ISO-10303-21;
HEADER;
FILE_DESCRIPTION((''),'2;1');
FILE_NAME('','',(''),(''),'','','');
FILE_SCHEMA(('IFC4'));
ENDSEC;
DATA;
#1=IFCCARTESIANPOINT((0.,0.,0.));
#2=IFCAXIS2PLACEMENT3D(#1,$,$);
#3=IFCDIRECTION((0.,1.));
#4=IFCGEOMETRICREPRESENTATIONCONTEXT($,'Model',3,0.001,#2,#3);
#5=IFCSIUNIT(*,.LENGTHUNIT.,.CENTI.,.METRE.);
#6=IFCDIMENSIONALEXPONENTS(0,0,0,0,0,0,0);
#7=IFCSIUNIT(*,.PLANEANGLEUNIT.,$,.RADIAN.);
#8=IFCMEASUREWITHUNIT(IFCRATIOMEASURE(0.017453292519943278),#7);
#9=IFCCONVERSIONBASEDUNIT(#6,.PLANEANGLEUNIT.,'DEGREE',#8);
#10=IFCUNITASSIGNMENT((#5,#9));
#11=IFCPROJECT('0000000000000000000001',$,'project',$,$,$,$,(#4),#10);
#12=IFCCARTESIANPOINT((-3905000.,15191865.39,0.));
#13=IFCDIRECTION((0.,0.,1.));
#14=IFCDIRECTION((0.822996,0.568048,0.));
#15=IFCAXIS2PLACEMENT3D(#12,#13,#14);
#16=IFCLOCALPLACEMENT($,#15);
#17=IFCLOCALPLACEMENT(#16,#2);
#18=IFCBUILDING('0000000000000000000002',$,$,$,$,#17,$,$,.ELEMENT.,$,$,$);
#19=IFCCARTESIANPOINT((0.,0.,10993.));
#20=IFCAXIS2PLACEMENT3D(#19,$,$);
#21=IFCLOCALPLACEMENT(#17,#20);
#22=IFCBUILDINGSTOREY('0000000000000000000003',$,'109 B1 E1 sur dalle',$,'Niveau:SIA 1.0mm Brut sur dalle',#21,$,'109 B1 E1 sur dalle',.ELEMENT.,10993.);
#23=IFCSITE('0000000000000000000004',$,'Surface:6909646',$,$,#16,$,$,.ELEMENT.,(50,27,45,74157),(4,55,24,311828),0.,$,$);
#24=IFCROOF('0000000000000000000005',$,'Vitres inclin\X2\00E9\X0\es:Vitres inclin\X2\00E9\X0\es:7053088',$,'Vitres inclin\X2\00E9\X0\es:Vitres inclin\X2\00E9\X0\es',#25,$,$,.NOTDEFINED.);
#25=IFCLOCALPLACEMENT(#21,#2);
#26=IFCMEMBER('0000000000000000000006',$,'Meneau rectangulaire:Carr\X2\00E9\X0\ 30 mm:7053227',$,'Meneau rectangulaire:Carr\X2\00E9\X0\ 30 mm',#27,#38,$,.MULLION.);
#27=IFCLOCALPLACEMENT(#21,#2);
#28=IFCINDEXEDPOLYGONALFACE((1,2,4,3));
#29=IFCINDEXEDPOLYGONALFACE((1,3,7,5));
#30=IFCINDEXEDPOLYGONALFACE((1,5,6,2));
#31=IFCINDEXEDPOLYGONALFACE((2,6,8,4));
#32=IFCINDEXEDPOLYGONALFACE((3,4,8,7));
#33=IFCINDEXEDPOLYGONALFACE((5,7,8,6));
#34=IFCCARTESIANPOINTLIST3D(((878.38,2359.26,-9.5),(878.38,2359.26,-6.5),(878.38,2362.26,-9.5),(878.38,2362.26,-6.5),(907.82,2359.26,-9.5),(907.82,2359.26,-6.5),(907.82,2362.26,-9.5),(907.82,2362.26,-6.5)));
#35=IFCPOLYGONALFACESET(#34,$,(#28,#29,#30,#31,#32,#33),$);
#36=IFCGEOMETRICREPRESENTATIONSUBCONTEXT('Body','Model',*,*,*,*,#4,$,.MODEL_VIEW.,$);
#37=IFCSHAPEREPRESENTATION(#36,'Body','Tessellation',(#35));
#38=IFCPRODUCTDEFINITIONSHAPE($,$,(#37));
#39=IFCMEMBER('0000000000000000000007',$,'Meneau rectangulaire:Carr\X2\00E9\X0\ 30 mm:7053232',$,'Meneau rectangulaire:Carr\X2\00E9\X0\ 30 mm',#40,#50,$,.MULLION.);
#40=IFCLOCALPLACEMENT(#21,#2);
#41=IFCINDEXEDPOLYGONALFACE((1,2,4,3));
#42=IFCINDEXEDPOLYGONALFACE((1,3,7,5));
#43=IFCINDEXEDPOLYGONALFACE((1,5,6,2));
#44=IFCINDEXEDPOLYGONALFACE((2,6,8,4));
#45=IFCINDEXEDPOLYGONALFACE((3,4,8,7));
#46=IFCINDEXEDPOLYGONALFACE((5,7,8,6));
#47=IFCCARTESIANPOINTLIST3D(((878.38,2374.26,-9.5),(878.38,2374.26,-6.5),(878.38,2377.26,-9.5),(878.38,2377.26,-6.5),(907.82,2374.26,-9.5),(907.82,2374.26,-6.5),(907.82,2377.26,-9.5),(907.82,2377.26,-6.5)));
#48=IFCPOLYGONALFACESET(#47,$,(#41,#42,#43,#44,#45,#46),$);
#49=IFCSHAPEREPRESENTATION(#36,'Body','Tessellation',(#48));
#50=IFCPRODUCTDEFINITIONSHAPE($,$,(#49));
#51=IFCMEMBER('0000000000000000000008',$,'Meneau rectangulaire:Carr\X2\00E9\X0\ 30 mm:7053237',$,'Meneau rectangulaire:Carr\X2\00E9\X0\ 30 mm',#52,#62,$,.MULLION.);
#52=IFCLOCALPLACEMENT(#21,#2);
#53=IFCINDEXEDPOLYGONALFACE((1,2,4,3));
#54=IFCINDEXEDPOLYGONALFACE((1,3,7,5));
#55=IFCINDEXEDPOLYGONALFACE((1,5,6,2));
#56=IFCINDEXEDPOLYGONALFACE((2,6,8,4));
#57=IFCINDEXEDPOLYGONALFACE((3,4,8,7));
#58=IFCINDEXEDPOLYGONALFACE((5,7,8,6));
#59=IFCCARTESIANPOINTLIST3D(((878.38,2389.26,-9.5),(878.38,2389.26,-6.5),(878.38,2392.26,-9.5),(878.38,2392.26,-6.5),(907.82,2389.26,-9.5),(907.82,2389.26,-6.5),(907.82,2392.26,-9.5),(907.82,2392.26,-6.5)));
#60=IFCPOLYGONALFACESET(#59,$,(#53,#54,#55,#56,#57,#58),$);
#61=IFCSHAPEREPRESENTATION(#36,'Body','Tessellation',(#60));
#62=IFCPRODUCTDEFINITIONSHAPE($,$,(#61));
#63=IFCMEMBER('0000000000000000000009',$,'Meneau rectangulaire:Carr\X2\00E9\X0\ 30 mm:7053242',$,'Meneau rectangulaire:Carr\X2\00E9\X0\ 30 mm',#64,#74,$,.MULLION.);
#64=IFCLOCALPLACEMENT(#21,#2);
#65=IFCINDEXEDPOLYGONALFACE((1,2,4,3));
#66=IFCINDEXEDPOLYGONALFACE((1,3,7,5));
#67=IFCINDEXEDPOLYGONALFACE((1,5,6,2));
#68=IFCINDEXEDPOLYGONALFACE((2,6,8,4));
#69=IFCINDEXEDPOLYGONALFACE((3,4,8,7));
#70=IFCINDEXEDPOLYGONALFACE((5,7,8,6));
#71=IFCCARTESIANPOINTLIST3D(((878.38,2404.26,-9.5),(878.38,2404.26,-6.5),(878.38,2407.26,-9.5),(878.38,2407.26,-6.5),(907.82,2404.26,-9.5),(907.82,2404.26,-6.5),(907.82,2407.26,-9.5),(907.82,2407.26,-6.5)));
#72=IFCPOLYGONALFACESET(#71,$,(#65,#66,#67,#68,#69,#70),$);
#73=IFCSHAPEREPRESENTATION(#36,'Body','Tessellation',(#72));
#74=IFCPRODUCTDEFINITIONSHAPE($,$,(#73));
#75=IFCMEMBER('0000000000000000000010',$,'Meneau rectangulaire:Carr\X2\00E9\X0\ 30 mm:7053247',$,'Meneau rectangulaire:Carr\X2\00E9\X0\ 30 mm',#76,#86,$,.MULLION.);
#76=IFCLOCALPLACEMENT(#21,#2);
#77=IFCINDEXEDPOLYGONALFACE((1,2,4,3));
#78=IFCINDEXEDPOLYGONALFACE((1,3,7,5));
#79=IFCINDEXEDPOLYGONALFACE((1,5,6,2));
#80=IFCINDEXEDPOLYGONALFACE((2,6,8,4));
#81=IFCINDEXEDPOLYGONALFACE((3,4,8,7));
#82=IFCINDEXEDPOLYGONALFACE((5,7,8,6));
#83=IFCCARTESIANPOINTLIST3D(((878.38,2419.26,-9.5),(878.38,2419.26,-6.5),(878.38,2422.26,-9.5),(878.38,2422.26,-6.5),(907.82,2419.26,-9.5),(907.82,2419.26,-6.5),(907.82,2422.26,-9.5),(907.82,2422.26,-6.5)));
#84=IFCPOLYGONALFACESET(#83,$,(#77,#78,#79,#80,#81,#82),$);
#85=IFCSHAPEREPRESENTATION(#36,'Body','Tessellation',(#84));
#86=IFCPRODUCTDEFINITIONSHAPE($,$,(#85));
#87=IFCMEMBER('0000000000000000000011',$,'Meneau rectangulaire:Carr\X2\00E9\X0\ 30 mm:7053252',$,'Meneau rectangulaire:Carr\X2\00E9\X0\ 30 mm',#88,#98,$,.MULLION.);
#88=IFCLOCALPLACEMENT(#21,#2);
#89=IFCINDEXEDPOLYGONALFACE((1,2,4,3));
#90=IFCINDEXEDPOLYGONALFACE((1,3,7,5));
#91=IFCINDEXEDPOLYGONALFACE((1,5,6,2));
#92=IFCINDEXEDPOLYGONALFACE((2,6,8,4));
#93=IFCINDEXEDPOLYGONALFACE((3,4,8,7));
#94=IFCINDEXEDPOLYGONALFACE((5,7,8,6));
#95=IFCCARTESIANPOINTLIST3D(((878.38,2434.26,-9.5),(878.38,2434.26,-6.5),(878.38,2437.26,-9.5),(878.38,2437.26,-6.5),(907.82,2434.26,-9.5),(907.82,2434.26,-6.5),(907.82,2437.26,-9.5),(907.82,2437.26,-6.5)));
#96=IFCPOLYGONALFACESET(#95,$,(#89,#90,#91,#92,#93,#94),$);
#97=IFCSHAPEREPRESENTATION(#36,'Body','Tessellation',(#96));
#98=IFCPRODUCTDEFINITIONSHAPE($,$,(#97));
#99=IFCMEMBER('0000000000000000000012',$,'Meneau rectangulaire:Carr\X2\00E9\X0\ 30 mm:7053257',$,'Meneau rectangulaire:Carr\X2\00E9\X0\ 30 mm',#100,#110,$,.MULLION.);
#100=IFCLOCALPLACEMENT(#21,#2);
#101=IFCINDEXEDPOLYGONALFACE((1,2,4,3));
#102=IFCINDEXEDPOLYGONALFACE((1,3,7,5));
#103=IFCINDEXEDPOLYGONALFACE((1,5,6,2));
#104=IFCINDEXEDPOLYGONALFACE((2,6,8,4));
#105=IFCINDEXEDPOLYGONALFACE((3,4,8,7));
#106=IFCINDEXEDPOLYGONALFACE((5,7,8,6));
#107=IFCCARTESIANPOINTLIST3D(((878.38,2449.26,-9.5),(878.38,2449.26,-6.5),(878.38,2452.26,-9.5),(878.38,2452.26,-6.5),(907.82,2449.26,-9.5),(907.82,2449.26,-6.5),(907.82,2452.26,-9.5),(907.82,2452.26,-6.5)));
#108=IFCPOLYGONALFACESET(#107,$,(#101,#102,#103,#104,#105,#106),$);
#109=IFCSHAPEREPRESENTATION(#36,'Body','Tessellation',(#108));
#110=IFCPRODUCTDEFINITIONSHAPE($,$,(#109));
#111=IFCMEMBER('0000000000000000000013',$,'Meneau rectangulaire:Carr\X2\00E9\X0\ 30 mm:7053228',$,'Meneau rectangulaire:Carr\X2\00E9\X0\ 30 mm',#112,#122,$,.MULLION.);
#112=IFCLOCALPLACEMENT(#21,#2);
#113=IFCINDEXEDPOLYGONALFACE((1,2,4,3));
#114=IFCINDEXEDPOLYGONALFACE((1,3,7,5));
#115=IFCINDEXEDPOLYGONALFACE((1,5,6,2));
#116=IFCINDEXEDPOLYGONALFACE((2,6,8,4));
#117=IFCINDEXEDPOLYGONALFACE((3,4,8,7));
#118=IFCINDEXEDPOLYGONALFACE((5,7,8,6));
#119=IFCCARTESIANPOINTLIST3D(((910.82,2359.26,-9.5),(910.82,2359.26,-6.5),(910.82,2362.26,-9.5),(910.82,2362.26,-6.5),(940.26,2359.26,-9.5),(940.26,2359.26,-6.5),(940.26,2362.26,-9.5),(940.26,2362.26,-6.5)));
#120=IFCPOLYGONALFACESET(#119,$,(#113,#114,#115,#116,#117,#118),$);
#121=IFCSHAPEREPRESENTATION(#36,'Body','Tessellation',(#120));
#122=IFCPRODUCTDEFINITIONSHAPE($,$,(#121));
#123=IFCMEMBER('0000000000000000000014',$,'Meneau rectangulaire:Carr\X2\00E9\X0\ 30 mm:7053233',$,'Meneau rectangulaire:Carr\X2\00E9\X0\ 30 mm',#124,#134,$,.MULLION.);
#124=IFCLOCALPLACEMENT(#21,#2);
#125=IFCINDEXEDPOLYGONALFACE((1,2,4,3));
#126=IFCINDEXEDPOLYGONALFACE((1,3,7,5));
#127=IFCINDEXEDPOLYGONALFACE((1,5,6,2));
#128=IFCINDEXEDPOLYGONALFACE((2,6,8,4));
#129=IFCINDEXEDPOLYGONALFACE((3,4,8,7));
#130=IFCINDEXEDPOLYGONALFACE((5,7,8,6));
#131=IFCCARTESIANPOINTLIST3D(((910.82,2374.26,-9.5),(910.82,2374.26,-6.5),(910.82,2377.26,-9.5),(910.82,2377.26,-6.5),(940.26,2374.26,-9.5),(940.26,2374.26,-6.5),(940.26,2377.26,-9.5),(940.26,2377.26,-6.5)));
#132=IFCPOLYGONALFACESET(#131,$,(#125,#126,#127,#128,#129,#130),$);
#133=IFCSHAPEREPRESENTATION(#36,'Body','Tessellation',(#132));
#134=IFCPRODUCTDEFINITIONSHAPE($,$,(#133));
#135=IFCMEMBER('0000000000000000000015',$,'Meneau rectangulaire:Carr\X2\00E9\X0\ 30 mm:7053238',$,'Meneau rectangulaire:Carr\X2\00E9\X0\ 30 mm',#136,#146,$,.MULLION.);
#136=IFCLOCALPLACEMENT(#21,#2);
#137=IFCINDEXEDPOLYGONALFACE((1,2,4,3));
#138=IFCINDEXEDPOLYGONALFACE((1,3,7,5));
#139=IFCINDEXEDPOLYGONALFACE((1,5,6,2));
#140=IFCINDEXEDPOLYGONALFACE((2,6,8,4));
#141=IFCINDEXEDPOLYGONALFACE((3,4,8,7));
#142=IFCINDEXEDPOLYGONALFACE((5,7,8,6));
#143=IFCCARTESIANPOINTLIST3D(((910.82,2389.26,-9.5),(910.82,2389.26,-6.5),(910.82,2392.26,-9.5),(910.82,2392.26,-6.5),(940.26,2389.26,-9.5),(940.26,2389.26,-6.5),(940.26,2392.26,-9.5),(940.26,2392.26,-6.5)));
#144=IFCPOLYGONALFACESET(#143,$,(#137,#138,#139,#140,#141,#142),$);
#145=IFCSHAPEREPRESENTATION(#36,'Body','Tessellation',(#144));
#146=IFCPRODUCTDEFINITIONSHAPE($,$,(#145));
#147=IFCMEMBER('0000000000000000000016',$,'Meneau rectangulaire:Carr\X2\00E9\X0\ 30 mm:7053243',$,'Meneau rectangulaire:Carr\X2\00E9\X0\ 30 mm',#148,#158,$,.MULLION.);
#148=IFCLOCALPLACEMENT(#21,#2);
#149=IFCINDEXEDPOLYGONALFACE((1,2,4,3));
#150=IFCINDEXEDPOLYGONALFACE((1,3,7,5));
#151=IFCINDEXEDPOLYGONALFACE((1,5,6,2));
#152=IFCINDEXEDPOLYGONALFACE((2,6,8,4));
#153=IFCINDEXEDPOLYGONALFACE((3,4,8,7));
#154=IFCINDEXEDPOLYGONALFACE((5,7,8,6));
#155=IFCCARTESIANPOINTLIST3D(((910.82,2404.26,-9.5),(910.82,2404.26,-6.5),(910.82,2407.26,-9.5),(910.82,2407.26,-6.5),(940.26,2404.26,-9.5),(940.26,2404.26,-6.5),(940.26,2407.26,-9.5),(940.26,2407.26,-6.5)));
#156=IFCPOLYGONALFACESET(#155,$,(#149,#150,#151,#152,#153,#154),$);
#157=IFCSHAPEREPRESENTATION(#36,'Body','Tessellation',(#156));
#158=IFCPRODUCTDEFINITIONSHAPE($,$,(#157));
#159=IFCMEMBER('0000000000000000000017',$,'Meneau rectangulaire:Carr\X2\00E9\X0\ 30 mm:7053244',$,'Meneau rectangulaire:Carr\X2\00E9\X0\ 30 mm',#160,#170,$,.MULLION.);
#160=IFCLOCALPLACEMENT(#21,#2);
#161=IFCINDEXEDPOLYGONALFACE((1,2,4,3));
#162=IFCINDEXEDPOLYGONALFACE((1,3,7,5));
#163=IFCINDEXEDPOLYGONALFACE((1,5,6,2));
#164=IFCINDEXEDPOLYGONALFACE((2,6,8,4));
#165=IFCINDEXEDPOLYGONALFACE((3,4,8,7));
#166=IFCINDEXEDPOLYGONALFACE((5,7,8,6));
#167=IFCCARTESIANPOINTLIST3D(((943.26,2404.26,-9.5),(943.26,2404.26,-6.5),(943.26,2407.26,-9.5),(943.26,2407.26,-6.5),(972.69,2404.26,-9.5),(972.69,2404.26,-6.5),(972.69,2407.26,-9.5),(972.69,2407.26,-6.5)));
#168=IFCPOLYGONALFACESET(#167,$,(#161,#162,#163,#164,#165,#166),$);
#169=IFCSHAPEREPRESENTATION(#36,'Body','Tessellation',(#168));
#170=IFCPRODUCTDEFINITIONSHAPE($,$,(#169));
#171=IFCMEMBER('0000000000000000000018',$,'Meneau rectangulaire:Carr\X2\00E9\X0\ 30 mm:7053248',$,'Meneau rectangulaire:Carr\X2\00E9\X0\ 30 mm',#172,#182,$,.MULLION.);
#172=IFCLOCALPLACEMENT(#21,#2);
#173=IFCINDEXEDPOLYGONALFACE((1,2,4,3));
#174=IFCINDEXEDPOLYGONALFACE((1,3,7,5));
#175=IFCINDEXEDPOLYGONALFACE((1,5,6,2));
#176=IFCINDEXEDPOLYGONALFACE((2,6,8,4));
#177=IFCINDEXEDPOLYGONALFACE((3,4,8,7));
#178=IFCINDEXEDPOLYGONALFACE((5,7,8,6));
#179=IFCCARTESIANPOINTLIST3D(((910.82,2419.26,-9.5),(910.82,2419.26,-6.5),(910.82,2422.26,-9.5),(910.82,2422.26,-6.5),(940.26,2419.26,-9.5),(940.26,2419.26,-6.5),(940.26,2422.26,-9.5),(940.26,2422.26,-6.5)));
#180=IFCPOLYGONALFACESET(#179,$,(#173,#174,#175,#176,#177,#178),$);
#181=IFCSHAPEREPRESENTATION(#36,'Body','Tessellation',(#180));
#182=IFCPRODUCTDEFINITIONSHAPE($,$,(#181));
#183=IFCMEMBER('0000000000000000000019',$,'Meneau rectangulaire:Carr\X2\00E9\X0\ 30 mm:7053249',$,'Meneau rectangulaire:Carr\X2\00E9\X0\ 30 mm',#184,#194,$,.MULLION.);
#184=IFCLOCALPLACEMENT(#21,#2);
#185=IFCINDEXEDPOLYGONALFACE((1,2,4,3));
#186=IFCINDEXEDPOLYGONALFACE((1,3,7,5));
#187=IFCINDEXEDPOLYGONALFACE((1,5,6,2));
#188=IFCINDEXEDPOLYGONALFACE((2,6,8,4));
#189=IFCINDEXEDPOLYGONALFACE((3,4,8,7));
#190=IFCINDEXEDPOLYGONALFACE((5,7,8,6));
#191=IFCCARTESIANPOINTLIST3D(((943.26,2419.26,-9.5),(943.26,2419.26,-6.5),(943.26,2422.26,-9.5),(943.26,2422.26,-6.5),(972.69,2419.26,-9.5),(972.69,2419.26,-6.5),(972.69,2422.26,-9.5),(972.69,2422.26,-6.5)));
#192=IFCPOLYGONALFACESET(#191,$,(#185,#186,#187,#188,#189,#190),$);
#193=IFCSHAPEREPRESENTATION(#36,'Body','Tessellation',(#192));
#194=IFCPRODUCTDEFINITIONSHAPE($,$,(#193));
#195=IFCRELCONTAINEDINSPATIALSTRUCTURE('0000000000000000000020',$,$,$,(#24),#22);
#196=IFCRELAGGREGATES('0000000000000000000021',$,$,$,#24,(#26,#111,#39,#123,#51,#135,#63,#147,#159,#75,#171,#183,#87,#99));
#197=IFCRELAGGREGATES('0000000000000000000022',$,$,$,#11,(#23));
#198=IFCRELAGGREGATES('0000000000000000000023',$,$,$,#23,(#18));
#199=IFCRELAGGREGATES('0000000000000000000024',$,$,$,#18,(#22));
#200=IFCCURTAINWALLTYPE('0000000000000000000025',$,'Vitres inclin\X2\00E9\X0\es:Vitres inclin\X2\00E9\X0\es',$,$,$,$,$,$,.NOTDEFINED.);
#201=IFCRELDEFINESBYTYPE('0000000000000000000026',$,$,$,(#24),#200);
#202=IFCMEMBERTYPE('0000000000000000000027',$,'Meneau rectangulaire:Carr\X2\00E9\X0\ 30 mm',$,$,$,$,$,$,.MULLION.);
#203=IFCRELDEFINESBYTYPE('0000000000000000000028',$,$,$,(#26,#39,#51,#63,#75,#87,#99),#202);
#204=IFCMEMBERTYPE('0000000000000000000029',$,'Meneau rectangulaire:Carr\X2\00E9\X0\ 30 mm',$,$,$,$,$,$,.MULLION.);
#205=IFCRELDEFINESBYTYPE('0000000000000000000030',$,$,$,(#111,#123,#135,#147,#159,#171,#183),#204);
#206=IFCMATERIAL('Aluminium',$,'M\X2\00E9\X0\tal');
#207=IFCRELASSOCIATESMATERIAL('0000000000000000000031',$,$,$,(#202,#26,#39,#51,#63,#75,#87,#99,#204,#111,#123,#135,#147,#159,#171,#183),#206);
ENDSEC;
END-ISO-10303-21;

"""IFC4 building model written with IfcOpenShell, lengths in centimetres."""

from ifc_helpers import new_model, entity, si_unit, converted_unit, direction, frame, origin, place, context, subcontext, project, spatial, indexed_curve, outline, extrude, source, transform, mapped, material, type_object, type_shapes, element, aggregate, save


model = new_model("IFC4")

# Units and contexts
model_context = context("Model", 3, precision=0.001, world=origin(), true_north=direction((0.0, 1.0)))
body_context = subcontext(model_context, "Body", "Model", "MODEL_VIEW")
ifc_project = project(units=[si_unit("LENGTHUNIT", "METRE", prefix="CENTI"), converted_unit("PLANEANGLEUNIT", "DEGREE", entity("IfcRatioMeasure", 0.017453292519943278), si_unit("PLANEANGLEUNIT", "RADIAN"), dimensions=[0, 0, 0, 0, 0, 0, 0])], contexts=[model_context])

# Site, building, storey
site_placement = place(None, frame((-3905000.0, 15191865.39, 0.0), z_axis=(0.0, 0.0, 1.0), x_axis=(0.822996, 0.568048, 0.0)))
site = spatial("IfcSite", under=ifc_project, at=site_placement, Name="Surface:6909646", CompositionType="ELEMENT", RefLatitude=(50, 27, 45, 74157), RefLongitude=(4, 55, 24, 311828), RefElevation=0.0)
building_placement = place(site_placement, origin())
building = spatial("IfcBuilding", under=site, at=building_placement, CompositionType="ELEMENT")
storey_placement = place(building_placement, frame((0.0, 0.0, 10993.0)))
storey = spatial("IfcBuildingStorey", under=building, at=storey_placement, Name="109 B1 E1 sur dalle", ObjectType="Niveau:SIA 1.0mm Brut sur dalle", LongName="109 B1 E1 sur dalle", CompositionType="ELEMENT", Elevation=10993.0)

# Roof, members
curtain_wall_type = type_object("IfcCurtainWallType", Name="Vitres inclinées:Vitres inclinées", PredefinedType="NOTDEFINED")
roof_placement = place(storey_placement, frame((0.0, 0.0, -10993.0)))
roof = element("IfcRoof", 1, at=roof_placement, inside=storey, type_object=curtain_wall_type, Name="Vitres inclinées:Vitres inclinées:7053088", ObjectType="Vitres inclinées:Vitres inclinées", PredefinedType="NOTDEFINED")
ifc_material = material(Name="Aluminium", Category="Métal")
member_type_1 = type_object("IfcMemberType", Name="Meneau rectangulaire:Carré 30 mm", PredefinedType="MULLION", material=ifc_material)
shared_shape_1 = source(origin(), body_context, "Body", "SweptSolid", [
    extrude(outline(indexed_curve([(-1.5, -1.5), (1.5, -1.5), (1.5, 1.5), (-1.5, 1.5), (-1.5, -1.5)], self_intersect=False)), frame((0.0, 0.0, -29.44), z_axis=(0.0, 0.0, 1.0), x_axis=(0.0, -1.0, 0.0)), (0.0, 0.0, 1.0), 29.44),
])
type_shapes(member_type_1, [shared_shape_1])
member_1_placement = place(roof_placement, frame((878.38, 2360.76, 10985.0), z_axis=(-1.0, 0.0, 0.0), x_axis=(0.0, 1.0, 0.0)))
member_1 = element("IfcMember", 2, at=member_1_placement, type_object=member_type_1, material=ifc_material, Name="Meneau rectangulaire:Carré 30 mm:7053227", ObjectType="Meneau rectangulaire:Carré 30 mm", PredefinedType="MULLION", context=body_context, shape_type="MappedRepresentation", body=[
    mapped(shared_shape_1, transform((0.0, 0.0, 0.0), scale=1.0)),
])
member_2_placement = place(roof_placement, frame((878.38, 2375.76, 10985.0), z_axis=(-1.0, 0.0, 0.0), x_axis=(0.0, 1.0, 0.0)))
member_2 = element("IfcMember", 3, at=member_2_placement, type_object=member_type_1, material=ifc_material, Name="Meneau rectangulaire:Carré 30 mm:7053232", ObjectType="Meneau rectangulaire:Carré 30 mm", PredefinedType="MULLION", context=body_context, shape_type="MappedRepresentation", body=[
    mapped(shared_shape_1, transform((0.0, 0.0, 0.0), scale=1.0)),
])
member_3_placement = place(roof_placement, frame((878.38, 2390.76, 10985.0), z_axis=(-1.0, 0.0, 0.0), x_axis=(0.0, 1.0, 0.0)))
member_3 = element("IfcMember", 4, at=member_3_placement, type_object=member_type_1, material=ifc_material, Name="Meneau rectangulaire:Carré 30 mm:7053237", ObjectType="Meneau rectangulaire:Carré 30 mm", PredefinedType="MULLION", context=body_context, shape_type="MappedRepresentation", body=[
    mapped(shared_shape_1, transform((0.0, 0.0, 0.0), scale=1.0)),
])
member_4_placement = place(roof_placement, frame((878.38, 2405.76, 10985.0), z_axis=(-1.0, 0.0, 0.0), x_axis=(0.0, 1.0, 0.0)))
member_4 = element("IfcMember", 5, at=member_4_placement, type_object=member_type_1, material=ifc_material, Name="Meneau rectangulaire:Carré 30 mm:7053242", ObjectType="Meneau rectangulaire:Carré 30 mm", PredefinedType="MULLION", context=body_context, shape_type="MappedRepresentation", body=[
    mapped(shared_shape_1, transform((0.0, 0.0, 0.0), scale=1.0)),
])
member_5_placement = place(roof_placement, frame((878.38, 2420.76, 10985.0), z_axis=(-1.0, 0.0, 0.0), x_axis=(0.0, 1.0, 0.0)))
member_5 = element("IfcMember", 6, at=member_5_placement, type_object=member_type_1, material=ifc_material, Name="Meneau rectangulaire:Carré 30 mm:7053247", ObjectType="Meneau rectangulaire:Carré 30 mm", PredefinedType="MULLION", context=body_context, shape_type="MappedRepresentation", body=[
    mapped(shared_shape_1, transform((0.0, 0.0, 0.0), scale=1.0)),
])
member_6_placement = place(roof_placement, frame((878.38, 2435.76, 10985.0), z_axis=(-1.0, 0.0, 0.0), x_axis=(0.0, 1.0, 0.0)))
member_6 = element("IfcMember", 7, at=member_6_placement, type_object=member_type_1, material=ifc_material, Name="Meneau rectangulaire:Carré 30 mm:7053252", ObjectType="Meneau rectangulaire:Carré 30 mm", PredefinedType="MULLION", context=body_context, shape_type="MappedRepresentation", body=[
    mapped(shared_shape_1, transform((0.0, 0.0, 0.0), scale=1.0)),
])
member_7_placement = place(roof_placement, frame((878.38, 2450.76, 10985.0), z_axis=(-1.0, 0.0, 0.0), x_axis=(0.0, 1.0, 0.0)))
member_7 = element("IfcMember", 8, at=member_7_placement, type_object=member_type_1, material=ifc_material, Name="Meneau rectangulaire:Carré 30 mm:7053257", ObjectType="Meneau rectangulaire:Carré 30 mm", PredefinedType="MULLION", context=body_context, shape_type="MappedRepresentation", body=[
    mapped(shared_shape_1, transform((0.0, 0.0, 0.0), scale=1.0)),
])
member_type_2 = type_object("IfcMemberType", Name="Meneau rectangulaire:Carré 30 mm", PredefinedType="MULLION", material=ifc_material)
shared_shape_2 = source(origin(), body_context, "Body", "SweptSolid", [
    extrude(outline(indexed_curve([(-1.5, -1.5), (1.5, -1.5), (1.5, 1.5), (-1.5, 1.5), (-1.5, -1.5)], self_intersect=False)), frame((0.0, 0.0, -29.44), z_axis=(0.0, 0.0, 1.0), x_axis=(0.0, -1.0, 0.0)), (0.0, 0.0, 1.0), 29.44),
])
type_shapes(member_type_2, [shared_shape_2])
member_8_placement = place(roof_placement, frame((910.82, 2360.76, 10985.0), z_axis=(-1.0, 0.0, 0.0), x_axis=(0.0, 1.0, 0.0)))
member_8 = element("IfcMember", 9, at=member_8_placement, type_object=member_type_2, material=ifc_material, Name="Meneau rectangulaire:Carré 30 mm:7053228", ObjectType="Meneau rectangulaire:Carré 30 mm", PredefinedType="MULLION", context=body_context, shape_type="MappedRepresentation", body=[
    mapped(shared_shape_2, transform((0.0, 0.0, 0.0), scale=1.0)),
])
member_9_placement = place(roof_placement, frame((910.82, 2375.76, 10985.0), z_axis=(-1.0, 0.0, 0.0), x_axis=(0.0, 1.0, 0.0)))
member_9 = element("IfcMember", 10, at=member_9_placement, type_object=member_type_2, material=ifc_material, Name="Meneau rectangulaire:Carré 30 mm:7053233", ObjectType="Meneau rectangulaire:Carré 30 mm", PredefinedType="MULLION", context=body_context, shape_type="MappedRepresentation", body=[
    mapped(shared_shape_2, transform((0.0, 0.0, 0.0), scale=1.0)),
])
member_10_placement = place(roof_placement, frame((910.82, 2390.76, 10985.0), z_axis=(-1.0, 0.0, 0.0), x_axis=(0.0, 1.0, 0.0)))
member_10 = element("IfcMember", 11, at=member_10_placement, type_object=member_type_2, material=ifc_material, Name="Meneau rectangulaire:Carré 30 mm:7053238", ObjectType="Meneau rectangulaire:Carré 30 mm", PredefinedType="MULLION", context=body_context, shape_type="MappedRepresentation", body=[
    mapped(shared_shape_2, transform((0.0, 0.0, 0.0), scale=1.0)),
])
member_11_placement = place(roof_placement, frame((910.82, 2405.76, 10985.0), z_axis=(-1.0, 0.0, 0.0), x_axis=(0.0, 1.0, 0.0)))
member_11 = element("IfcMember", 12, at=member_11_placement, type_object=member_type_2, material=ifc_material, Name="Meneau rectangulaire:Carré 30 mm:7053243", ObjectType="Meneau rectangulaire:Carré 30 mm", PredefinedType="MULLION", context=body_context, shape_type="MappedRepresentation", body=[
    mapped(shared_shape_2, transform((0.0, 0.0, 0.0), scale=1.0)),
])
member_12_placement = place(roof_placement, frame((943.26, 2405.76, 10985.0), z_axis=(-1.0, 0.0, 0.0), x_axis=(0.0, 1.0, 0.0)))
member_12 = element("IfcMember", 13, at=member_12_placement, type_object=member_type_2, material=ifc_material, Name="Meneau rectangulaire:Carré 30 mm:7053244", ObjectType="Meneau rectangulaire:Carré 30 mm", PredefinedType="MULLION", context=body_context, shape_type="MappedRepresentation", body=[
    mapped(shared_shape_2, transform((0.0, 0.0, 0.0), scale=1.0)),
])
member_13_placement = place(roof_placement, frame((910.82, 2420.76, 10985.0), z_axis=(-1.0, 0.0, 0.0), x_axis=(0.0, 1.0, 0.0)))
member_13 = element("IfcMember", 14, at=member_13_placement, type_object=member_type_2, material=ifc_material, Name="Meneau rectangulaire:Carré 30 mm:7053248", ObjectType="Meneau rectangulaire:Carré 30 mm", PredefinedType="MULLION", context=body_context, shape_type="MappedRepresentation", body=[
    mapped(shared_shape_2, transform((0.0, 0.0, 0.0), scale=1.0)),
])
member_14_placement = place(roof_placement, frame((943.26, 2420.76, 10985.0), z_axis=(-1.0, 0.0, 0.0), x_axis=(0.0, 1.0, 0.0)))
member_14 = element("IfcMember", 15, at=member_14_placement, type_object=member_type_2, material=ifc_material, Name="Meneau rectangulaire:Carré 30 mm:7053249", ObjectType="Meneau rectangulaire:Carré 30 mm", PredefinedType="MULLION", context=body_context, shape_type="MappedRepresentation", body=[
    mapped(shared_shape_2, transform((0.0, 0.0, 0.0), scale=1.0)),
])
aggregate(roof, [member_1, member_8, member_2, member_9, member_3, member_10, member_4, member_11, member_12, member_5, member_13, member_14, member_6, member_7])

save(model, "model.ifc")
